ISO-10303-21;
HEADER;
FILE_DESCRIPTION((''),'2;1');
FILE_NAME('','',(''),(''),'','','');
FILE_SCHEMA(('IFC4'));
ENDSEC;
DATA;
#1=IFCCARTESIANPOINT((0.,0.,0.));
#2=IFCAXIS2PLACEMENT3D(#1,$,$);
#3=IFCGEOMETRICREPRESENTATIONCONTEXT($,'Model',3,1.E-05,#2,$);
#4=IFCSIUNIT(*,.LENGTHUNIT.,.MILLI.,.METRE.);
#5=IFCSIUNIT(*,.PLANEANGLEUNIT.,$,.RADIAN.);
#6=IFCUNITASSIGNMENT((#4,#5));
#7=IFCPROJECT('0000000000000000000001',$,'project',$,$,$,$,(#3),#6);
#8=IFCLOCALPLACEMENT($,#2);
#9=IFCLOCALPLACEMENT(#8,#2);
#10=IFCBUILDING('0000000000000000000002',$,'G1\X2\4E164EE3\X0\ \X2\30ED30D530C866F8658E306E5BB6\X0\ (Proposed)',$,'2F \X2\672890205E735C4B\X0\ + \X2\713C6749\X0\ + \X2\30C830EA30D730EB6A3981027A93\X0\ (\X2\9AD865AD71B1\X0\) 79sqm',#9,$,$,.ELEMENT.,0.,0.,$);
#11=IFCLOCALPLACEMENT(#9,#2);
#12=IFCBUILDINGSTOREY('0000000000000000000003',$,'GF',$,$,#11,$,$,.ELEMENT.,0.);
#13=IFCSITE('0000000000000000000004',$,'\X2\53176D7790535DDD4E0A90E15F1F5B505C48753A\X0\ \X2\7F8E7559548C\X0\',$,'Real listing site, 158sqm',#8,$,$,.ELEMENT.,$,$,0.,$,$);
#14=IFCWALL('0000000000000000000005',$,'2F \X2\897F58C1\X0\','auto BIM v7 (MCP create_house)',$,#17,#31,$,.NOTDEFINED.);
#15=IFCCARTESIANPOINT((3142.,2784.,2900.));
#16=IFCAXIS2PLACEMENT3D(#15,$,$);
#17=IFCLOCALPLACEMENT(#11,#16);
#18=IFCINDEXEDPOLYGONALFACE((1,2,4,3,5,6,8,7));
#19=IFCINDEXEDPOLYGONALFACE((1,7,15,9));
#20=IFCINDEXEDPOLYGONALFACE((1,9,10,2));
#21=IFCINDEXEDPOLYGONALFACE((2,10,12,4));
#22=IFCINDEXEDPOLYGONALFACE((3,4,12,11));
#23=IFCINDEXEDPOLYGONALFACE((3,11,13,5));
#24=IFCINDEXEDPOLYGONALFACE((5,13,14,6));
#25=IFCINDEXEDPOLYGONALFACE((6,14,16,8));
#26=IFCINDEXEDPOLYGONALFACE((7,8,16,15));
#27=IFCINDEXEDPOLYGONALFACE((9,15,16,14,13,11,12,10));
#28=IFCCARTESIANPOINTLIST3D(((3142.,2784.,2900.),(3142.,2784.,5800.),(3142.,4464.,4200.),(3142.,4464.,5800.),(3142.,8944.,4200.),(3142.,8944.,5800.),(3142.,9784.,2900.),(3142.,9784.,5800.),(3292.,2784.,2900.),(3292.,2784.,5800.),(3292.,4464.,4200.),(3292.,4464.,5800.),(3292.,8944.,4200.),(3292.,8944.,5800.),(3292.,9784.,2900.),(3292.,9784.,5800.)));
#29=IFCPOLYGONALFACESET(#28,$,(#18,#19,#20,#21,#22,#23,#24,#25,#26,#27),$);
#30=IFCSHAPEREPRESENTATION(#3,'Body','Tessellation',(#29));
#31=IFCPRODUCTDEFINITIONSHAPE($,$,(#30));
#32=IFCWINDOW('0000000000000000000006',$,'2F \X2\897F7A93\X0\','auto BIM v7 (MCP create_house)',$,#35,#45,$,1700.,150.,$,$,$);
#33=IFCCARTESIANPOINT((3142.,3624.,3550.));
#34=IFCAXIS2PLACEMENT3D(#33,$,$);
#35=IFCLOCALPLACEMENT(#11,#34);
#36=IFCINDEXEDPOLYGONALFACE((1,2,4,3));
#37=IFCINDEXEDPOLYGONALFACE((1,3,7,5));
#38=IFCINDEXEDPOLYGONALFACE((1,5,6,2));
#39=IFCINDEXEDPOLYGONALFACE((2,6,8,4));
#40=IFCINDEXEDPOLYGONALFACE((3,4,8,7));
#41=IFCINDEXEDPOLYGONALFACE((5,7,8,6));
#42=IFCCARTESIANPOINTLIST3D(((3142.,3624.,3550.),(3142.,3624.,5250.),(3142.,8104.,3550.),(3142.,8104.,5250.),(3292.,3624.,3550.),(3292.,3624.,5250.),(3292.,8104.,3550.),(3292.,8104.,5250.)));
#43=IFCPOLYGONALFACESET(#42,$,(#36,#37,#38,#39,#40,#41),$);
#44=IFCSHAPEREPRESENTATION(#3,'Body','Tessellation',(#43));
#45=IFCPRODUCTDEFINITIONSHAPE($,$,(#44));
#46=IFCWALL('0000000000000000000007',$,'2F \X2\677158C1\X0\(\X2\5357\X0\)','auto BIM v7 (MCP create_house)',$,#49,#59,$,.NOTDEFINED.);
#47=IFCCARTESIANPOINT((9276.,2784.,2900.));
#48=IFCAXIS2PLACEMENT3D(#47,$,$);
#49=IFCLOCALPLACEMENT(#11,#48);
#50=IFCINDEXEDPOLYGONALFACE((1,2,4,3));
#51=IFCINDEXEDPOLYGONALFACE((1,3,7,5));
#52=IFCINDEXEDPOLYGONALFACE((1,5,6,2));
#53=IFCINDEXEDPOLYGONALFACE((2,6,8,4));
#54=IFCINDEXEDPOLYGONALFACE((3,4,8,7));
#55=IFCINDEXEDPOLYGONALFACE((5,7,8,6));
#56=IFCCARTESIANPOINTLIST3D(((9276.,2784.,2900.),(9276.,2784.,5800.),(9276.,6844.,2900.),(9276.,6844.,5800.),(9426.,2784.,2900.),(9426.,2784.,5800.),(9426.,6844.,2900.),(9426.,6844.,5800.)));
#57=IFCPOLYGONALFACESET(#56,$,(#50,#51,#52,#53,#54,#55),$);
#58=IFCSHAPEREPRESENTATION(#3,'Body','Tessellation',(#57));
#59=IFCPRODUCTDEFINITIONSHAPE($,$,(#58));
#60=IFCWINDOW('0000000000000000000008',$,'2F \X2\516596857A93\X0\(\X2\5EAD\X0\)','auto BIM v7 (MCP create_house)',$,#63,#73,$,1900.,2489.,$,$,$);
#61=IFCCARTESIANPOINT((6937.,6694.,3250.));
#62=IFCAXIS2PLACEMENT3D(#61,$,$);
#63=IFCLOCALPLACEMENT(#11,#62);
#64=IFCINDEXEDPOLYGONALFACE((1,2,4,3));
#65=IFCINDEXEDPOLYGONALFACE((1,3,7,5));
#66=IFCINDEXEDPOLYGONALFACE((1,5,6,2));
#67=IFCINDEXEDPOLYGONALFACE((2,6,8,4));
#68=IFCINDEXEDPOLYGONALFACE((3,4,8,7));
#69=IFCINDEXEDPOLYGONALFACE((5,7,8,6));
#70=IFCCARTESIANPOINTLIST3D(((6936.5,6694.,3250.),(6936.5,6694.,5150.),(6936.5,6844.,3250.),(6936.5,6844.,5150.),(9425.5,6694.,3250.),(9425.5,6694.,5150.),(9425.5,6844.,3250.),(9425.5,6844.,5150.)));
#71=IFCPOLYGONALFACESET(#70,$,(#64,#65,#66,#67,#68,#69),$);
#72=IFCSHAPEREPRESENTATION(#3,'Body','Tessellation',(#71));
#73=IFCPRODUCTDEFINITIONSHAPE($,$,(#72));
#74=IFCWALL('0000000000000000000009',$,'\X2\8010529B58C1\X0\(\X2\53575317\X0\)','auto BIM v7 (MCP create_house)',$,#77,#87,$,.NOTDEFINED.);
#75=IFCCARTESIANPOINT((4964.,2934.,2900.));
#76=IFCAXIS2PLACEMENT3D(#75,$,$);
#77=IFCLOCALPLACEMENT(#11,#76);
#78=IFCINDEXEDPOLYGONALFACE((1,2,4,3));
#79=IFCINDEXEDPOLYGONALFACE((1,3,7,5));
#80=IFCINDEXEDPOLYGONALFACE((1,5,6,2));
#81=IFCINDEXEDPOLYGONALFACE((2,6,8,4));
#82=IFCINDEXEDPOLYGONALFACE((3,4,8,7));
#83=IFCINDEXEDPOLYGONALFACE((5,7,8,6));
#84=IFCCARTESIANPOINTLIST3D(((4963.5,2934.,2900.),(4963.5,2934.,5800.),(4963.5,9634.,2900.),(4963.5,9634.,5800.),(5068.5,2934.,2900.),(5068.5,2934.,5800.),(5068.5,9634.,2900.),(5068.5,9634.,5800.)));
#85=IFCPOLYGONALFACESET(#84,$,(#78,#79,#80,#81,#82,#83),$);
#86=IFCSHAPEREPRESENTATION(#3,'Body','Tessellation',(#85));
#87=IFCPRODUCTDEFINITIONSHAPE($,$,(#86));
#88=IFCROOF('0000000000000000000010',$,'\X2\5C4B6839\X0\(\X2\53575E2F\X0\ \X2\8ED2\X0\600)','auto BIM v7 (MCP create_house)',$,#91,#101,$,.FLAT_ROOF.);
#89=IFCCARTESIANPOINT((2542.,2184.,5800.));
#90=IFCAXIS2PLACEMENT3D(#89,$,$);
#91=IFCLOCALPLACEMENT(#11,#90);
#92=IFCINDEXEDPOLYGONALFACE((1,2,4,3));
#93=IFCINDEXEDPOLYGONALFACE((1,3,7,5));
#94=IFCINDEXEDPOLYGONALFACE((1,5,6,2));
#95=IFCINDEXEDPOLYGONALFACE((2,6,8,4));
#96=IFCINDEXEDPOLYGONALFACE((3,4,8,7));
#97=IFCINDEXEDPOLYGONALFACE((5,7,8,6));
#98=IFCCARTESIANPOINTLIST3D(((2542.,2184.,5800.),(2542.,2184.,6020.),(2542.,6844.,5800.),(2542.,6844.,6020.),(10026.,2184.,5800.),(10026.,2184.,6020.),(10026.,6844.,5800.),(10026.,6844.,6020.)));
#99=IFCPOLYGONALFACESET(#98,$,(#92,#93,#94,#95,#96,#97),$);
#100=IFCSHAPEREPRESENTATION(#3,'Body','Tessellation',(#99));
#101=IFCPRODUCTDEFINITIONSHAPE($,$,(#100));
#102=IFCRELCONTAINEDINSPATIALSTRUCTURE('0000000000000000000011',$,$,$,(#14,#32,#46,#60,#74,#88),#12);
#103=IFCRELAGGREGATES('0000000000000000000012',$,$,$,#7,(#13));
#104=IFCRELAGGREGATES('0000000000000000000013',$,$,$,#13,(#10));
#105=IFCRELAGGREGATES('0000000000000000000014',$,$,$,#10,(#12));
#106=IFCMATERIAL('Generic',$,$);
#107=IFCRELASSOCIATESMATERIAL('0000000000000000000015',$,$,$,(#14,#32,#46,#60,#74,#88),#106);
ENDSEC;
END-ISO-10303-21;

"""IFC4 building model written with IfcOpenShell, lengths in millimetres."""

from ifc_helpers import new_model, si_unit, frame, frame_2d, origin, place, context, project, spatial, rectangle, extrude, material, element, fill, save


model = new_model("IFC4")

# Units and contexts
model_context = context("Model", 3, precision=1e-05, world=origin())
ifc_project = project(units=[si_unit("LENGTHUNIT", "METRE", prefix="MILLI"), si_unit("PLANEANGLEUNIT", "RADIAN")], contexts=[model_context])

# Site, building, storey
site_placement = place(None, origin())
site = spatial("IfcSite", under=ifc_project, at=site_placement, Name="北海道川上郡弟子屈町 美留和", ObjectType="Real listing site, 158sqm", CompositionType="ELEMENT", RefElevation=0.0)
building_placement = place(site_placement, origin())
building = spatial("IfcBuilding", under=site, at=building_placement, Name="G1世代 ロフト書斎の家 (Proposed)", ObjectType="2F 木造平屋 + 焼杉 + トリプル樹脂窓 (高断熱) 79sqm", CompositionType="ELEMENT", ElevationOfRefHeight=0.0, ElevationOfTerrain=0.0)
storey_placement = place(building_placement, origin())
storey = spatial("IfcBuildingStorey", under=building, at=storey_placement, Name="GF", CompositionType="ELEMENT", Elevation=0.0)

# Shared definitions
ifc_material = material(Name="Generic")

# Walls, openings, windows
wall_1_placement = place(storey_placement, frame((3142.0, 2784.0, 2900.0)))
wall_1 = element("IfcWall", 1, at=wall_1_placement, inside=storey, material=ifc_material, Name="2F 西壁", Description="auto BIM v7 (MCP create_house)", PredefinedType="NOTDEFINED", context=model_context, shape_type="SweptSolid", body=[
    extrude(rectangle(XDim=150.0, YDim=7000.0, at=frame_2d((75.0, 3500.0))), frame((3142.0, 2784.0, 2900.0)), (0.0, 0.0, 1.0), 2900.0),
])
opening_1_placement = place(storey_placement, frame((3142.0, 3624.0, 3550.0)))
opening_1 = element("IfcOpeningElement", 2, at=opening_1_placement, cuts=wall_1, PredefinedType="NOTDEFINED", context=model_context, shape_type="SweptSolid", body=[
    extrude(rectangle(XDim=150.0, YDim=4480.0, at=frame_2d((75.0, 2240.0))), frame((3142.0, 3624.0, 3550.0)), (0.0, 0.0, 1.0), 1700.0),
])
window_1_placement = place(storey_placement, frame((3142.0, 3624.0, 3550.0)))
window_1 = element("IfcWindow", 3, at=window_1_placement, inside=storey, material=ifc_material, Name="2F 西窓", Description="auto BIM v7 (MCP create_house)", OverallHeight=1700.0, OverallWidth=150.0, context=model_context, shape_type="SweptSolid", body=[
    extrude(rectangle(XDim=150.0, YDim=4480.0, at=frame_2d((75.0, 2240.0))), frame((3142.0, 3624.0, 3550.0)), (0.0, 0.0, 1.0), 1700.0),
])
fill(opening_1, window_1)
wall_2_placement = place(storey_placement, frame((9276.0, 2784.0, 2900.0)))
wall_2 = element("IfcWall", 4, at=wall_2_placement, inside=storey, material=ifc_material, Name="2F 東壁(南)", Description="auto BIM v7 (MCP create_house)", PredefinedType="NOTDEFINED", context=model_context, shape_type="SweptSolid", body=[
    extrude(rectangle(XDim=150.0, YDim=4060.0, at=frame_2d((75.0, 2030.0))), frame((9276.0, 2784.0, 2900.0)), (0.0, 0.0, 1.0), 2900.0),
])
opening_2_placement = place(storey_placement, frame((6937.0, 6694.0, 3250.0)))
opening_2 = element("IfcOpeningElement", 5, at=opening_2_placement, cuts=wall_2, PredefinedType="NOTDEFINED", context=model_context, shape_type="SweptSolid", body=[
    extrude(rectangle(XDim=2489.0, YDim=150.0, at=frame_2d((1244.0, 75.0))), frame((6937.0, 6694.0, 3250.0)), (0.0, 0.0, 1.0), 1900.0),
])
window_2_placement = place(storey_placement, frame((6937.0, 6694.0, 3250.0)))
window_2 = element("IfcWindow", 6, at=window_2_placement, inside=storey, material=ifc_material, Name="2F 入隅窓(庭)", Description="auto BIM v7 (MCP create_house)", OverallHeight=1900.0, OverallWidth=2489.0, context=model_context, shape_type="SweptSolid", body=[
    extrude(rectangle(XDim=2489.0, YDim=150.0, at=frame_2d((1244.0, 75.0))), frame((6937.0, 6694.0, 3250.0)), (0.0, 0.0, 1.0), 1900.0),
])
fill(opening_2, window_2)

# Wall
wall_3_placement = place(storey_placement, frame((4964.0, 2934.0, 2900.0)))
element("IfcWall", 7, at=wall_3_placement, inside=storey, material=ifc_material, Name="耐力壁(南北)", Description="auto BIM v7 (MCP create_house)", PredefinedType="NOTDEFINED", context=model_context, shape_type="SweptSolid", body=[
    extrude(rectangle(XDim=105.0, YDim=6700.0, at=frame_2d((52.0, 3350.0))), frame((4964.0, 2934.0, 2900.0)), (0.0, 0.0, 1.0), 2900.0),
])

# Roof
for number, where, name in (
    (8, (2542.0, 2184.0, 5800.0), "屋根(南帯 軒600)"),
):
    element("IfcRoof", number, at=place(storey_placement, frame(where)), inside=storey, material=ifc_material, Name=name, Description="auto BIM v7 (MCP create_house)", PredefinedType="FLAT_ROOF", context=model_context, shape_type="SweptSolid", body=[
        extrude(rectangle(XDim=7484.0, YDim=4660.0, at=frame_2d((3742.0, 2330.0))), frame((2542.0, 2184.0, 5800.0)), (0.0, 0.0, 1.0), 220.0),
    ])

save(model, "model.ifc")
